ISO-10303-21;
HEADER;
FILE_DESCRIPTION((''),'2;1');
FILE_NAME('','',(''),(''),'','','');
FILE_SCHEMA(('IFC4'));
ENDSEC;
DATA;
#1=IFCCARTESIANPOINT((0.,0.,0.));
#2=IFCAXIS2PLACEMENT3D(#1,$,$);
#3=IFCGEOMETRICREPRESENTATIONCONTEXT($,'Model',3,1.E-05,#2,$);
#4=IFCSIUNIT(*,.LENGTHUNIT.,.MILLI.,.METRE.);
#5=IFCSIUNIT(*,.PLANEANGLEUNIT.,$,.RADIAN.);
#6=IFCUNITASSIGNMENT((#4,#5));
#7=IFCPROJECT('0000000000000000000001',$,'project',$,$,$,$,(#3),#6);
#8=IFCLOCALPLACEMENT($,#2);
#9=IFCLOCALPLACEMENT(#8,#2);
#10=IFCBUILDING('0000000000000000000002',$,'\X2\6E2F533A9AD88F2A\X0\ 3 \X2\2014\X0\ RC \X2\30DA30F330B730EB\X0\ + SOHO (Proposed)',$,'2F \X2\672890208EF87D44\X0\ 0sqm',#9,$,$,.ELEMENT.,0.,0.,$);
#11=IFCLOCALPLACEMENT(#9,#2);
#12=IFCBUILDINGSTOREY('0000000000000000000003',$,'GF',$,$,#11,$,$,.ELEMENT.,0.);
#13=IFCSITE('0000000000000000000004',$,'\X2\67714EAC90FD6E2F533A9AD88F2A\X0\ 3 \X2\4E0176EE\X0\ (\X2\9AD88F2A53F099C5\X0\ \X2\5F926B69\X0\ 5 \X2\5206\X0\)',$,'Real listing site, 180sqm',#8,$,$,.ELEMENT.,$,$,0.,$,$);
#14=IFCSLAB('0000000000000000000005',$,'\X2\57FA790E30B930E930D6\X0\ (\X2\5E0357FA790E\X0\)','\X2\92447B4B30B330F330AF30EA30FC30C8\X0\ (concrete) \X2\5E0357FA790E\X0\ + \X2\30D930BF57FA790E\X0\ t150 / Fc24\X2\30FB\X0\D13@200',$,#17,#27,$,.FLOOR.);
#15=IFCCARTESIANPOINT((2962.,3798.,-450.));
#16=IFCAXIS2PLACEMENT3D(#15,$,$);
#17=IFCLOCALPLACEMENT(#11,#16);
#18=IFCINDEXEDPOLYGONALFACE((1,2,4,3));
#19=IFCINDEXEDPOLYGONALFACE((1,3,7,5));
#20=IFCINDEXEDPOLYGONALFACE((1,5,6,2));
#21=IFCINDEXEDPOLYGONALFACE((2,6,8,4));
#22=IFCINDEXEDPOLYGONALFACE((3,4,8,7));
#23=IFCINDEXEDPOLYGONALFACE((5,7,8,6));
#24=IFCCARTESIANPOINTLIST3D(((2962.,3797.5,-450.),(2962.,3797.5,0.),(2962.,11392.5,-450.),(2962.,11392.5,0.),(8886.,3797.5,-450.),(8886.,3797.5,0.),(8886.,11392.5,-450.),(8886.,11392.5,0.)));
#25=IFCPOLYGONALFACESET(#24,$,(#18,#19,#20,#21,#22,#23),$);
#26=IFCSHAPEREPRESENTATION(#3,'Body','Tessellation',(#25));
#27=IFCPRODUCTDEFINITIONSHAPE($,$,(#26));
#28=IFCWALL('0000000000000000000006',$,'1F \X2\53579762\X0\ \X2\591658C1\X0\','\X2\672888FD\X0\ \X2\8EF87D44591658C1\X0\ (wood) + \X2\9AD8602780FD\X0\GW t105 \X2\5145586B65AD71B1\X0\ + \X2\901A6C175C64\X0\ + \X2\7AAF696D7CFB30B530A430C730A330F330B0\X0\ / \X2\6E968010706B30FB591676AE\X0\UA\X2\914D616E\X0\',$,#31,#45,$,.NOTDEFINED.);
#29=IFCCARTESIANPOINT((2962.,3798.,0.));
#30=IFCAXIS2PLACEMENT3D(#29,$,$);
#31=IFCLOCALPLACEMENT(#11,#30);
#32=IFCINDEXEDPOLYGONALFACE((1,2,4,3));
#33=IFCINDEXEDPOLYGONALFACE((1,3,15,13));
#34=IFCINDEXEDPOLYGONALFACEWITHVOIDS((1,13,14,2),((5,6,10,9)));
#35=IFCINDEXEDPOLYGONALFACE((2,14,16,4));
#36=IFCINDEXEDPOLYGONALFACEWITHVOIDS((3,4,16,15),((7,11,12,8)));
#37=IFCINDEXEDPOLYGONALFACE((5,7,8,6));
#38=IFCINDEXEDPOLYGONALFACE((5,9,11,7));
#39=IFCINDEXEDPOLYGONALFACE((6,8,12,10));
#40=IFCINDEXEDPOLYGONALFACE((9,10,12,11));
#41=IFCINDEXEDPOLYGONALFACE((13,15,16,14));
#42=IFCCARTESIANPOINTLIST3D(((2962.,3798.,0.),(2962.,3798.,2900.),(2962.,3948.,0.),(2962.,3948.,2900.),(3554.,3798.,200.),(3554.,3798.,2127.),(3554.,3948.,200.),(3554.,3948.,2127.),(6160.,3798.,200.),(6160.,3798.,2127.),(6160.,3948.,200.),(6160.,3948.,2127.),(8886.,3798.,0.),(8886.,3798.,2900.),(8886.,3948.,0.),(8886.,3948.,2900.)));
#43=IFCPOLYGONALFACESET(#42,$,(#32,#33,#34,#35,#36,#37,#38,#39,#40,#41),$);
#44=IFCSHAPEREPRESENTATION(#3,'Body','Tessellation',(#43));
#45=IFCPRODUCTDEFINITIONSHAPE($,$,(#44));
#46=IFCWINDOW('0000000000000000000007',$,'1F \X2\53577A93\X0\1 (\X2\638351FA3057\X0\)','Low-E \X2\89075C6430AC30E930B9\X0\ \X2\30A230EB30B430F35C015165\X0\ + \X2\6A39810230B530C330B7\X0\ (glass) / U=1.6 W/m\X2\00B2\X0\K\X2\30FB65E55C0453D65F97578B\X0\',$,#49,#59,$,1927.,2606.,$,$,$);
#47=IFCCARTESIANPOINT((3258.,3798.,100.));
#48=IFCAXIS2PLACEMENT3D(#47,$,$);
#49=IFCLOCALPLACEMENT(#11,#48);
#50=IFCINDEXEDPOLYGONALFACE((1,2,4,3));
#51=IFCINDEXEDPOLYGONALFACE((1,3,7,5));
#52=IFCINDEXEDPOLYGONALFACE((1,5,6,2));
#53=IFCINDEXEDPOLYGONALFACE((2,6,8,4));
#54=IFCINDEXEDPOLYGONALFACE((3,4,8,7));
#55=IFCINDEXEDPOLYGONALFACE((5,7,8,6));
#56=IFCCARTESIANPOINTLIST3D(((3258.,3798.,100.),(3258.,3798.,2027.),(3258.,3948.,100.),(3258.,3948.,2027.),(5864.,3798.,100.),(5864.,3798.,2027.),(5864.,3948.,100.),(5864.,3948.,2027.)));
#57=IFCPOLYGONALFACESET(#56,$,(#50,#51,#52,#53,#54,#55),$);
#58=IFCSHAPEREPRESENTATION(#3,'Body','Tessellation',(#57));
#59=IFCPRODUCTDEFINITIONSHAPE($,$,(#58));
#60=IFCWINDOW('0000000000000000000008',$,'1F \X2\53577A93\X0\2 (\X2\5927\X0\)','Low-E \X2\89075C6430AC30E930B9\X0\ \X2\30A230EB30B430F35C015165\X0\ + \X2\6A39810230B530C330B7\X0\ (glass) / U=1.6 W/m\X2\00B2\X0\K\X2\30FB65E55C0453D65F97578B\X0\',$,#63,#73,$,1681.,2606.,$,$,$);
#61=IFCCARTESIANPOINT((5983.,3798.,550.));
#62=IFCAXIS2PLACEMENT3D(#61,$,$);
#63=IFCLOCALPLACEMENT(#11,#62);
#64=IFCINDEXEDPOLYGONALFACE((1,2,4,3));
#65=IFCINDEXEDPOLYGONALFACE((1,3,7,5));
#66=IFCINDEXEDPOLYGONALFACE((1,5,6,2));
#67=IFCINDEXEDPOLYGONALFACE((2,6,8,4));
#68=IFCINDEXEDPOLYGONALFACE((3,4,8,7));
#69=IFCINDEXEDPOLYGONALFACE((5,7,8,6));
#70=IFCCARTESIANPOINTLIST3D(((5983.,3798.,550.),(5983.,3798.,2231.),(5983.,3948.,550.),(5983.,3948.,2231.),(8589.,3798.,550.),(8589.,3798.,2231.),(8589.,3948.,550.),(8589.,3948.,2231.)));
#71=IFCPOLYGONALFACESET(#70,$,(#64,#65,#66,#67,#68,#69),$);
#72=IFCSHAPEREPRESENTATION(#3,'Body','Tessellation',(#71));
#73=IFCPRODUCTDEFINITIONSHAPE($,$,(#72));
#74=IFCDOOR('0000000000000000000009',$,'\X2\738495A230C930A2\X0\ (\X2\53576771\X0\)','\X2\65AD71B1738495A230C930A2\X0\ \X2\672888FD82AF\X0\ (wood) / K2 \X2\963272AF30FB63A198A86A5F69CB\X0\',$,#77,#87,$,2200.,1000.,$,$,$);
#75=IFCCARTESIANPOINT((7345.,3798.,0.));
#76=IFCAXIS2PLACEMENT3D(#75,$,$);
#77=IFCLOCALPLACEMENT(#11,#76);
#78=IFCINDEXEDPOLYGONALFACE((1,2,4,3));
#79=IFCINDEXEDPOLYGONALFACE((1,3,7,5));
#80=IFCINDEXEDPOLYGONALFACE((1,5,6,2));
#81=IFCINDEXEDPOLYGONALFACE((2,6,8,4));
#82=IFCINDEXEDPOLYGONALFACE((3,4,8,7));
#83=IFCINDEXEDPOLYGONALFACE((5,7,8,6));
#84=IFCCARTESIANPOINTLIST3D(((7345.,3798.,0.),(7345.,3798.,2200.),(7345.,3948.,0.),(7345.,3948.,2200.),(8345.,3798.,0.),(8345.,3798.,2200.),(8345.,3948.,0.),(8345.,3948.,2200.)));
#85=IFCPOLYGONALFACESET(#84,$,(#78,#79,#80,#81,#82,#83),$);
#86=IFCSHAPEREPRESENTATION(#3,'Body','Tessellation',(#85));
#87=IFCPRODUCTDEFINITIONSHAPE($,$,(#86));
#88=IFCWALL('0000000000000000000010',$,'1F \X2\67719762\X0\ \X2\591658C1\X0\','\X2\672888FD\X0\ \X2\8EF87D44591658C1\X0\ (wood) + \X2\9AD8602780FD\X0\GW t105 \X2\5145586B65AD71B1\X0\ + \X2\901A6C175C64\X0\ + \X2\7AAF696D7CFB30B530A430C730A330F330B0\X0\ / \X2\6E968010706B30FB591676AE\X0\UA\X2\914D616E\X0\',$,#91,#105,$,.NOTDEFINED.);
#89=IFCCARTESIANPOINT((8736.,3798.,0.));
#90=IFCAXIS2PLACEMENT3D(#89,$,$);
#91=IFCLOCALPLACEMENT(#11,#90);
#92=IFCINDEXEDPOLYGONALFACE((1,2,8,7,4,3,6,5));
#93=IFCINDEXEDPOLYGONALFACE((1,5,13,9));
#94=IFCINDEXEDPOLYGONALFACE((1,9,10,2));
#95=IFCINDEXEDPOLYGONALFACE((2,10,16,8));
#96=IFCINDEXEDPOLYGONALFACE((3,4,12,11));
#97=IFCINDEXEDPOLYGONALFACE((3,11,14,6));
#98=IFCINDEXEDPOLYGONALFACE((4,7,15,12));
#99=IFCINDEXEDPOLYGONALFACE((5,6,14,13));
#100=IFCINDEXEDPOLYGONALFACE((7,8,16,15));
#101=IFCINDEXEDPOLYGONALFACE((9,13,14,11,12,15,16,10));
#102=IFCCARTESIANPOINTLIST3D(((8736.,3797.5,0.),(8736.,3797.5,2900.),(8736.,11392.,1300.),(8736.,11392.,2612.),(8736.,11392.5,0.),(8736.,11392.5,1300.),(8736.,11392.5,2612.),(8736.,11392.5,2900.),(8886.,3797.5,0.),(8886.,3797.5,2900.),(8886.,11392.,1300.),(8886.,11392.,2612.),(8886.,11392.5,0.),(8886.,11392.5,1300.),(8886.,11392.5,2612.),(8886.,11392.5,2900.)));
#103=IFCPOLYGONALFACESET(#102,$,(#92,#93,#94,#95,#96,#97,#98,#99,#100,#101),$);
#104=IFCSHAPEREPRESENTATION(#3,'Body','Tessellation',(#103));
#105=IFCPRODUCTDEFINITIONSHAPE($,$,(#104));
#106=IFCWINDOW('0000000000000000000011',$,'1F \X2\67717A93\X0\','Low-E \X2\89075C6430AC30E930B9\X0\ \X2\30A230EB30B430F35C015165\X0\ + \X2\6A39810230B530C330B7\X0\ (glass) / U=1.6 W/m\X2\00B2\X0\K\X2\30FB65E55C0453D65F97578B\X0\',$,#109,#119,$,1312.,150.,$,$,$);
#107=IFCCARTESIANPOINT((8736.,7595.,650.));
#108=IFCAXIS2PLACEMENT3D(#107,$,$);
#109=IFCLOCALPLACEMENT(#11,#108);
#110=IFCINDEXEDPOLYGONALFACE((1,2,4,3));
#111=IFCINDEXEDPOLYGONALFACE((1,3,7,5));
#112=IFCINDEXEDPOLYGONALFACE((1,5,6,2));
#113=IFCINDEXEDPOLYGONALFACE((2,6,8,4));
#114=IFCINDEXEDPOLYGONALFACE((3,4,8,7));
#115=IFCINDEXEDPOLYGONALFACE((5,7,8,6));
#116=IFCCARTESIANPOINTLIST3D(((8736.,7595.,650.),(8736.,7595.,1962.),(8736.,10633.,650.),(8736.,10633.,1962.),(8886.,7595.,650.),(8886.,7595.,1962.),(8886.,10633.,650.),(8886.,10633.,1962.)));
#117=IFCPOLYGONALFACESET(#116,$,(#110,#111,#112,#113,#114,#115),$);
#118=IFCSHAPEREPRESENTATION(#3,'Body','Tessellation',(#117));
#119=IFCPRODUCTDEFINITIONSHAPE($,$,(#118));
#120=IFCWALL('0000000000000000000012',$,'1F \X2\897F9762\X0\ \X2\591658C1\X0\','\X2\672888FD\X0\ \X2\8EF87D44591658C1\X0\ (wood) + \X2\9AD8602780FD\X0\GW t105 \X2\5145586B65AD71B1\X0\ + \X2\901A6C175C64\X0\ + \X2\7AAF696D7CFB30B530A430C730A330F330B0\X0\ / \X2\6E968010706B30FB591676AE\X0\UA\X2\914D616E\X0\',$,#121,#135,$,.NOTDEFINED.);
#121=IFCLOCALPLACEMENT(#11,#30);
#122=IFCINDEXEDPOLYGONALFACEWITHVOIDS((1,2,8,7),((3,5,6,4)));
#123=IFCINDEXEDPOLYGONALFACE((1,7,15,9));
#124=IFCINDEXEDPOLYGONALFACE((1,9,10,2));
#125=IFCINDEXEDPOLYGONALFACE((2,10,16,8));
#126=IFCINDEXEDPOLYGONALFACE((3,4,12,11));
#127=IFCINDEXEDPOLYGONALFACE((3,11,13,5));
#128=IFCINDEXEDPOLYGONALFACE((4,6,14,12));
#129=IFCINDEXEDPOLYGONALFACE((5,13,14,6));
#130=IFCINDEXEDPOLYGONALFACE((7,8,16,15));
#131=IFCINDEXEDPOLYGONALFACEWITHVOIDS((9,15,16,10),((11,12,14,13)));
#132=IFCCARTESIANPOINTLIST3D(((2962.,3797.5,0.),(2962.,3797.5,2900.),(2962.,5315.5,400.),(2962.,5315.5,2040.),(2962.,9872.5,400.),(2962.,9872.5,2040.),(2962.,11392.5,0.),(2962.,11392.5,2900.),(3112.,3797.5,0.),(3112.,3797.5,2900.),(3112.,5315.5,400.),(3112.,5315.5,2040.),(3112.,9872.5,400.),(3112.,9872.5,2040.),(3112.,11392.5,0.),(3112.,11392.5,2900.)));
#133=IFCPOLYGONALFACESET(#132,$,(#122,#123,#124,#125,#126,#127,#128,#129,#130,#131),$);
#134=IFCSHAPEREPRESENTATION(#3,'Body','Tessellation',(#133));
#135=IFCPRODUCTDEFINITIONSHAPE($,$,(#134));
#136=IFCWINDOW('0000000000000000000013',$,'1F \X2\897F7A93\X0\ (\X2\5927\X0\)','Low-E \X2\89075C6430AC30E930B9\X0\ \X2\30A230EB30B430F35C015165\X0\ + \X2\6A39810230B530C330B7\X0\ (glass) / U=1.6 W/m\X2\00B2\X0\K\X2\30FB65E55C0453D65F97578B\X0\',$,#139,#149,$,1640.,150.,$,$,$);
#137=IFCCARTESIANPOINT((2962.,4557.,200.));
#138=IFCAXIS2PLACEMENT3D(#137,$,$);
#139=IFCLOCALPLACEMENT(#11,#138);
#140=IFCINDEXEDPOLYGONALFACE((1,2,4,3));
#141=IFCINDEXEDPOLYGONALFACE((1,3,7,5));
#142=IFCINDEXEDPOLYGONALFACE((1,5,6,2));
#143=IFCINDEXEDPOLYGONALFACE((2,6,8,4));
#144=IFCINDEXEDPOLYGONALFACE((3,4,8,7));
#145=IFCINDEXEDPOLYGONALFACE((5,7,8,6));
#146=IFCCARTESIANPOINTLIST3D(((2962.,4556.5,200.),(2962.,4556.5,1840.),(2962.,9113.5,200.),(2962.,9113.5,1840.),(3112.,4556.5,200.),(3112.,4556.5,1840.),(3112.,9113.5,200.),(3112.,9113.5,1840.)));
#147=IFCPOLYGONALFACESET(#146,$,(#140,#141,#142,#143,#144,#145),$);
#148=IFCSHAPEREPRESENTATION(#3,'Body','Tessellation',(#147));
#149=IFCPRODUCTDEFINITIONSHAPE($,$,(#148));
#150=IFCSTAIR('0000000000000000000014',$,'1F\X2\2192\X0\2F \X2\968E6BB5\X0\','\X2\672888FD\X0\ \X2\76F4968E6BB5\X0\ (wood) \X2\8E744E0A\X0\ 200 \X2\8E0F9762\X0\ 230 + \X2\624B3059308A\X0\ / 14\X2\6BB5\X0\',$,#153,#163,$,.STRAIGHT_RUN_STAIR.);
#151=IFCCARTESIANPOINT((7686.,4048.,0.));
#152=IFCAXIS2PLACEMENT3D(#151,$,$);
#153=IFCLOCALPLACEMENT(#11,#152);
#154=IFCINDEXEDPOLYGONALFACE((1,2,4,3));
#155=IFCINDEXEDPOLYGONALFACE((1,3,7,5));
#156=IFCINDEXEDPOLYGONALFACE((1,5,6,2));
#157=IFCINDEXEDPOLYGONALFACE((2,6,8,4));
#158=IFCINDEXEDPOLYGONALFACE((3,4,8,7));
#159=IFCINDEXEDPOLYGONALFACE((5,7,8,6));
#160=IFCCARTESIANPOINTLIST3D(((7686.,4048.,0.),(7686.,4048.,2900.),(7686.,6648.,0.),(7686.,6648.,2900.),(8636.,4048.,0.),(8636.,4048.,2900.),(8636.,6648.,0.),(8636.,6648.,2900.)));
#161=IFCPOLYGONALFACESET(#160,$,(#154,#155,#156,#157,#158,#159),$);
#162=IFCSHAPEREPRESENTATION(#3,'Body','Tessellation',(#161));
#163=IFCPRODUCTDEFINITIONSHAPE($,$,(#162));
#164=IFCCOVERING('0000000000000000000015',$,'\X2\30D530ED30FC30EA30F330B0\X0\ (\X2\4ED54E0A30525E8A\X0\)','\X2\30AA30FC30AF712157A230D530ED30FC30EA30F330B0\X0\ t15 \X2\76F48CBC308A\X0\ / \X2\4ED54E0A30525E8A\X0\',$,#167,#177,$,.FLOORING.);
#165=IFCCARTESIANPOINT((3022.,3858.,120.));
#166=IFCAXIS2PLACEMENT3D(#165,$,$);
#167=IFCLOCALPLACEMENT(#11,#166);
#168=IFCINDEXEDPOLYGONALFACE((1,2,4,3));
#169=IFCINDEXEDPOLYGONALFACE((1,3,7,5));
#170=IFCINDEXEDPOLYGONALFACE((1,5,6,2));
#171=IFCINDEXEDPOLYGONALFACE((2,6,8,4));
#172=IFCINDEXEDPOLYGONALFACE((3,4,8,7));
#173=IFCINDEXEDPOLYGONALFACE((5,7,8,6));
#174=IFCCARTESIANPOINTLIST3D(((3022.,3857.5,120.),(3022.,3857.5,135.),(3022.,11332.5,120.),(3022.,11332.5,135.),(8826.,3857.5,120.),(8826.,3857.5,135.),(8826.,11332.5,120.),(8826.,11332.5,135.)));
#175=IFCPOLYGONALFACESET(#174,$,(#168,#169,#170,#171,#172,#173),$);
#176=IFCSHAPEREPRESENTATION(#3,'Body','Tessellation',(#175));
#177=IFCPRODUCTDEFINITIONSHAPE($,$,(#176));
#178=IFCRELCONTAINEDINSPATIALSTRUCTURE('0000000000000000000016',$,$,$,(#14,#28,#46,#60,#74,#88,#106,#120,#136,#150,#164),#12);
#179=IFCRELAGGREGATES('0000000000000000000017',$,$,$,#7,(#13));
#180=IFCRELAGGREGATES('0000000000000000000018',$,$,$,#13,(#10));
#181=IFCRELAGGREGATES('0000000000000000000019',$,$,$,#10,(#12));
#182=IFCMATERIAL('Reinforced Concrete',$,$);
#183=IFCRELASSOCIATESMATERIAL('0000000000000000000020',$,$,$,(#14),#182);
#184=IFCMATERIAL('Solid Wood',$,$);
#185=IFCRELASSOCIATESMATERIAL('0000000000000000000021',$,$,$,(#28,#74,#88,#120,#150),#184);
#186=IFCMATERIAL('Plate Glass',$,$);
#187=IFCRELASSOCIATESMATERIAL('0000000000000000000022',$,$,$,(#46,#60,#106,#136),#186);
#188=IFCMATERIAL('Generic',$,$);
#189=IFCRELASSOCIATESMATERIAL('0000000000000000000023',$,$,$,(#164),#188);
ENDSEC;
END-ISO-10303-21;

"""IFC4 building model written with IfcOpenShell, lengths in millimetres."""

from ifc_helpers import new_model, si_unit, frame, frame_2d, origin, place, context, project, spatial, rectangle, extrude, material, element, fill, save


model = new_model("IFC4")

# Units and contexts
model_context = context("Model", 3, precision=1e-05, world=origin())
ifc_project = project(units=[si_unit("LENGTHUNIT", "METRE", prefix="MILLI"), si_unit("PLANEANGLEUNIT", "RADIAN")], contexts=[model_context])

# Site, building, storey
site_placement = place(None, origin())
site = spatial("IfcSite", under=ifc_project, at=site_placement, Name="東京都港区高輪 3 丁目 (高輪台駅 徒歩 5 分)", ObjectType="Real listing site, 180sqm", CompositionType="ELEMENT", RefElevation=0.0)
building_placement = place(site_placement, origin())
building = spatial("IfcBuilding", under=site, at=building_placement, Name="港区高輪 3 — RC ペンシル + SOHO (Proposed)", ObjectType="2F 木造軸組 0sqm", CompositionType="ELEMENT", ElevationOfRefHeight=0.0, ElevationOfTerrain=0.0)
storey_placement = place(building_placement, origin())
storey = spatial("IfcBuildingStorey", under=building, at=storey_placement, Name="GF", CompositionType="ELEMENT", Elevation=0.0)

# Slab
ifc_material_1 = material(Name="Reinforced Concrete")
slab_1_placement = place(storey_placement, frame((2962.0, 3798.0, -450.0)))
element("IfcSlab", 1, at=slab_1_placement, inside=storey, material=ifc_material_1, Name="基礎スラブ (布基礎)", Description="鉄筋コンクリート (concrete) 布基礎 + ベタ基礎 t150 / Fc24・D13@200", PredefinedType="FLOOR", context=model_context, shape_type="SweptSolid", body=[
    extrude(rectangle(XDim=5924.0, YDim=7595.0, at=frame_2d((2962.0, 3797.0))), frame((2962.0, 3798.0, -450.0)), (0.0, 0.0, 1.0), 450.0),
])
ifc_material_2 = material(Name="Solid Wood")

# Wall, openings, windows, door
wall_1_placement = place(storey_placement, frame((2962.0, 3798.0, 0.0)))
wall_1 = element("IfcWall", 2, at=wall_1_placement, inside=storey, material=ifc_material_2, Name="1F 南面 外壁", Description="木製 軸組外壁 (wood) + 高性能GW t105 充填断熱 + 通気層 + 窯業系サイディング / 準耐火・外皮UA配慮", PredefinedType="NOTDEFINED", context=model_context, shape_type="SweptSolid", body=[
    extrude(rectangle(XDim=5924.0, YDim=150.0, at=frame_2d((2962.0, 75.0))), frame((2962.0, 3798.0, 0.0)), (0.0, 0.0, 1.0), 2900.0),
])
opening_1_placement = place(storey_placement, frame((3258.0, 3798.0, 100.0)))
opening_1 = element("IfcOpeningElement", 3, at=opening_1_placement, cuts=wall_1, PredefinedType="NOTDEFINED", context=model_context, shape_type="SweptSolid", body=[
    extrude(rectangle(XDim=2606.0, YDim=150.0, at=frame_2d((1303.0, 75.0))), frame((3258.0, 3798.0, 100.0)), (0.0, 0.0, 1.0), 1927.0),
])
opening_2_placement = place(storey_placement, frame((5983.0, 3798.0, 550.0)))
opening_2 = element("IfcOpeningElement", 4, at=opening_2_placement, cuts=wall_1, PredefinedType="NOTDEFINED", context=model_context, shape_type="SweptSolid", body=[
    extrude(rectangle(XDim=2606.0, YDim=150.0, at=frame_2d((1303.0, 75.0))), frame((5983.0, 3798.0, 550.0)), (0.0, 0.0, 1.0), 1681.0),
])
opening_3_placement = place(storey_placement, frame((7345.0, 3798.0, 0.0)))
opening_3 = element("IfcOpeningElement", 5, at=opening_3_placement, cuts=wall_1, PredefinedType="NOTDEFINED", context=model_context, shape_type="SweptSolid", body=[
    extrude(rectangle(XDim=1000.0, YDim=150.0, at=frame_2d((500.0, 75.0))), frame((7345.0, 3798.0, 0.0)), (0.0, 0.0, 1.0), 2200.0),
])
ifc_material_3 = material(Name="Plate Glass")
window_1_placement = place(storey_placement, frame((3258.0, 3798.0, 100.0)))
window_1 = element("IfcWindow", 6, at=window_1_placement, inside=storey, material=ifc_material_3, Name="1F 南窓1 (掃出し)", Description="Low-E 複層ガラス アルゴン封入 + 樹脂サッシ (glass) / U=1.6 W/m²K・日射取得型", OverallHeight=1927.0, OverallWidth=2606.0, context=model_context, shape_type="SweptSolid", body=[
    extrude(rectangle(XDim=2606.0, YDim=150.0, at=frame_2d((1303.0, 75.0))), frame((3258.0, 3798.0, 100.0)), (0.0, 0.0, 1.0), 1927.0),
])
fill(opening_1, window_1)
window_2_placement = place(storey_placement, frame((5983.0, 3798.0, 550.0)))
window_2 = element("IfcWindow", 7, at=window_2_placement, inside=storey, material=ifc_material_3, Name="1F 南窓2 (大)", Description="Low-E 複層ガラス アルゴン封入 + 樹脂サッシ (glass) / U=1.6 W/m²K・日射取得型", OverallHeight=1681.0, OverallWidth=2606.0, context=model_context, shape_type="SweptSolid", body=[
    extrude(rectangle(XDim=2606.0, YDim=150.0, at=frame_2d((1303.0, 75.0))), frame((5983.0, 3798.0, 550.0)), (0.0, 0.0, 1.0), 1681.0),
])
fill(opening_2, window_2)
door_placement = place(storey_placement, frame((7345.0, 3798.0, 0.0)))
door = element("IfcDoor", 8, at=door_placement, inside=storey, material=ifc_material_2, Name="玄関ドア (南東)", Description="断熱玄関ドア 木製芯 (wood) / K2 防犯・採風機構", OverallHeight=2200.0, OverallWidth=1000.0, context=model_context, shape_type="SweptSolid", body=[
    extrude(rectangle(XDim=1000.0, YDim=150.0, at=frame_2d((500.0, 75.0))), frame((7345.0, 3798.0, 0.0)), (0.0, 0.0, 1.0), 2200.0),
])
fill(opening_3, door)

# Walls, openings, windows
wall_2_placement = place(storey_placement, frame((8736.0, 3798.0, 0.0)))
wall_2 = element("IfcWall", 9, at=wall_2_placement, inside=storey, material=ifc_material_2, Name="1F 東面 外壁", Description="木製 軸組外壁 (wood) + 高性能GW t105 充填断熱 + 通気層 + 窯業系サイディング / 準耐火・外皮UA配慮", PredefinedType="NOTDEFINED", context=model_context, shape_type="SweptSolid", body=[
    extrude(rectangle(XDim=150.0, YDim=7595.0, at=frame_2d((75.0, 3797.0))), frame((8736.0, 3798.0, 0.0)), (0.0, 0.0, 1.0), 2900.0),
])
opening_4_placement = place(storey_placement, frame((8736.0, 7595.0, 650.0)))
opening_4 = element("IfcOpeningElement", 10, at=opening_4_placement, cuts=wall_2, PredefinedType="NOTDEFINED", context=model_context, shape_type="SweptSolid", body=[
    extrude(rectangle(XDim=150.0, YDim=3038.0, at=frame_2d((75.0, 1519.0))), frame((8736.0, 7595.0, 650.0)), (0.0, 0.0, 1.0), 1312.0),
])
window_3_placement = place(storey_placement, frame((8736.0, 7595.0, 650.0)))
window_3 = element("IfcWindow", 11, at=window_3_placement, inside=storey, material=ifc_material_3, Name="1F 東窓", Description="Low-E 複層ガラス アルゴン封入 + 樹脂サッシ (glass) / U=1.6 W/m²K・日射取得型", OverallHeight=1312.0, OverallWidth=150.0, context=model_context, shape_type="SweptSolid", body=[
    extrude(rectangle(XDim=150.0, YDim=3038.0, at=frame_2d((75.0, 1519.0))), frame((8736.0, 7595.0, 650.0)), (0.0, 0.0, 1.0), 1312.0),
])
fill(opening_4, window_3)
wall_3_placement = place(storey_placement, frame((2962.0, 3798.0, 0.0)))
wall_3 = element("IfcWall", 12, at=wall_3_placement, inside=storey, material=ifc_material_2, Name="1F 西面 外壁", Description="木製 軸組外壁 (wood) + 高性能GW t105 充填断熱 + 通気層 + 窯業系サイディング / 準耐火・外皮UA配慮", PredefinedType="NOTDEFINED", context=model_context, shape_type="SweptSolid", body=[
    extrude(rectangle(XDim=150.0, YDim=7595.0, at=frame_2d((75.0, 3797.0))), frame((2962.0, 3798.0, 0.0)), (0.0, 0.0, 1.0), 2900.0),
])
opening_5_placement = place(storey_placement, frame((2962.0, 4557.0, 200.0)))
opening_5 = element("IfcOpeningElement", 13, at=opening_5_placement, cuts=wall_3, PredefinedType="NOTDEFINED", context=model_context, shape_type="SweptSolid", body=[
    extrude(rectangle(XDim=150.0, YDim=4557.0, at=frame_2d((75.0, 2278.0))), frame((2962.0, 4557.0, 200.0)), (0.0, 0.0, 1.0), 1640.0),
])
window_4_placement = place(storey_placement, frame((2962.0, 4557.0, 200.0)))
window_4 = element("IfcWindow", 14, at=window_4_placement, inside=storey, material=ifc_material_3, Name="1F 西窓 (大)", Description="Low-E 複層ガラス アルゴン封入 + 樹脂サッシ (glass) / U=1.6 W/m²K・日射取得型", OverallHeight=1640.0, OverallWidth=150.0, context=model_context, shape_type="SweptSolid", body=[
    extrude(rectangle(XDim=150.0, YDim=4557.0, at=frame_2d((75.0, 2278.0))), frame((2962.0, 4557.0, 200.0)), (0.0, 0.0, 1.0), 1640.0),
])
fill(opening_5, window_4)

# Stair
stair_placement = place(storey_placement, frame((7686.0, 4048.0, 0.0)))
element("IfcStair", 15, at=stair_placement, inside=storey, material=ifc_material_2, Name="1F→2F 階段", Description="木製 直階段 (wood) 蹴上 200 踏面 230 + 手すり / 14段", PredefinedType="STRAIGHT_RUN_STAIR", context=model_context, shape_type="SweptSolid", body=[
    extrude(rectangle(XDim=950.0, YDim=2600.0, at=frame_2d((475.0, 1300.0))), frame((7686.0, 4048.0, 0.0)), (0.0, 0.0, 1.0), 2900.0),
])

# Covering
ifc_material_4 = material(Name="Generic")
covering_placement = place(storey_placement, frame((3022.0, 3858.0, 120.0)))
element("IfcCovering", 16, at=covering_placement, inside=storey, material=ifc_material_4, Name="フローリング (仕上げ床)", Description="オーク無垢フローリング t15 直貼り / 仕上げ床", PredefinedType="FLOORING", context=model_context, shape_type="SweptSolid", body=[
    extrude(rectangle(XDim=5804.0, YDim=7475.0, at=frame_2d((2902.0, 3737.0))), frame((3022.0, 3858.0, 120.0)), (0.0, 0.0, 1.0), 15.0),
])

save(model, "model.ifc")
